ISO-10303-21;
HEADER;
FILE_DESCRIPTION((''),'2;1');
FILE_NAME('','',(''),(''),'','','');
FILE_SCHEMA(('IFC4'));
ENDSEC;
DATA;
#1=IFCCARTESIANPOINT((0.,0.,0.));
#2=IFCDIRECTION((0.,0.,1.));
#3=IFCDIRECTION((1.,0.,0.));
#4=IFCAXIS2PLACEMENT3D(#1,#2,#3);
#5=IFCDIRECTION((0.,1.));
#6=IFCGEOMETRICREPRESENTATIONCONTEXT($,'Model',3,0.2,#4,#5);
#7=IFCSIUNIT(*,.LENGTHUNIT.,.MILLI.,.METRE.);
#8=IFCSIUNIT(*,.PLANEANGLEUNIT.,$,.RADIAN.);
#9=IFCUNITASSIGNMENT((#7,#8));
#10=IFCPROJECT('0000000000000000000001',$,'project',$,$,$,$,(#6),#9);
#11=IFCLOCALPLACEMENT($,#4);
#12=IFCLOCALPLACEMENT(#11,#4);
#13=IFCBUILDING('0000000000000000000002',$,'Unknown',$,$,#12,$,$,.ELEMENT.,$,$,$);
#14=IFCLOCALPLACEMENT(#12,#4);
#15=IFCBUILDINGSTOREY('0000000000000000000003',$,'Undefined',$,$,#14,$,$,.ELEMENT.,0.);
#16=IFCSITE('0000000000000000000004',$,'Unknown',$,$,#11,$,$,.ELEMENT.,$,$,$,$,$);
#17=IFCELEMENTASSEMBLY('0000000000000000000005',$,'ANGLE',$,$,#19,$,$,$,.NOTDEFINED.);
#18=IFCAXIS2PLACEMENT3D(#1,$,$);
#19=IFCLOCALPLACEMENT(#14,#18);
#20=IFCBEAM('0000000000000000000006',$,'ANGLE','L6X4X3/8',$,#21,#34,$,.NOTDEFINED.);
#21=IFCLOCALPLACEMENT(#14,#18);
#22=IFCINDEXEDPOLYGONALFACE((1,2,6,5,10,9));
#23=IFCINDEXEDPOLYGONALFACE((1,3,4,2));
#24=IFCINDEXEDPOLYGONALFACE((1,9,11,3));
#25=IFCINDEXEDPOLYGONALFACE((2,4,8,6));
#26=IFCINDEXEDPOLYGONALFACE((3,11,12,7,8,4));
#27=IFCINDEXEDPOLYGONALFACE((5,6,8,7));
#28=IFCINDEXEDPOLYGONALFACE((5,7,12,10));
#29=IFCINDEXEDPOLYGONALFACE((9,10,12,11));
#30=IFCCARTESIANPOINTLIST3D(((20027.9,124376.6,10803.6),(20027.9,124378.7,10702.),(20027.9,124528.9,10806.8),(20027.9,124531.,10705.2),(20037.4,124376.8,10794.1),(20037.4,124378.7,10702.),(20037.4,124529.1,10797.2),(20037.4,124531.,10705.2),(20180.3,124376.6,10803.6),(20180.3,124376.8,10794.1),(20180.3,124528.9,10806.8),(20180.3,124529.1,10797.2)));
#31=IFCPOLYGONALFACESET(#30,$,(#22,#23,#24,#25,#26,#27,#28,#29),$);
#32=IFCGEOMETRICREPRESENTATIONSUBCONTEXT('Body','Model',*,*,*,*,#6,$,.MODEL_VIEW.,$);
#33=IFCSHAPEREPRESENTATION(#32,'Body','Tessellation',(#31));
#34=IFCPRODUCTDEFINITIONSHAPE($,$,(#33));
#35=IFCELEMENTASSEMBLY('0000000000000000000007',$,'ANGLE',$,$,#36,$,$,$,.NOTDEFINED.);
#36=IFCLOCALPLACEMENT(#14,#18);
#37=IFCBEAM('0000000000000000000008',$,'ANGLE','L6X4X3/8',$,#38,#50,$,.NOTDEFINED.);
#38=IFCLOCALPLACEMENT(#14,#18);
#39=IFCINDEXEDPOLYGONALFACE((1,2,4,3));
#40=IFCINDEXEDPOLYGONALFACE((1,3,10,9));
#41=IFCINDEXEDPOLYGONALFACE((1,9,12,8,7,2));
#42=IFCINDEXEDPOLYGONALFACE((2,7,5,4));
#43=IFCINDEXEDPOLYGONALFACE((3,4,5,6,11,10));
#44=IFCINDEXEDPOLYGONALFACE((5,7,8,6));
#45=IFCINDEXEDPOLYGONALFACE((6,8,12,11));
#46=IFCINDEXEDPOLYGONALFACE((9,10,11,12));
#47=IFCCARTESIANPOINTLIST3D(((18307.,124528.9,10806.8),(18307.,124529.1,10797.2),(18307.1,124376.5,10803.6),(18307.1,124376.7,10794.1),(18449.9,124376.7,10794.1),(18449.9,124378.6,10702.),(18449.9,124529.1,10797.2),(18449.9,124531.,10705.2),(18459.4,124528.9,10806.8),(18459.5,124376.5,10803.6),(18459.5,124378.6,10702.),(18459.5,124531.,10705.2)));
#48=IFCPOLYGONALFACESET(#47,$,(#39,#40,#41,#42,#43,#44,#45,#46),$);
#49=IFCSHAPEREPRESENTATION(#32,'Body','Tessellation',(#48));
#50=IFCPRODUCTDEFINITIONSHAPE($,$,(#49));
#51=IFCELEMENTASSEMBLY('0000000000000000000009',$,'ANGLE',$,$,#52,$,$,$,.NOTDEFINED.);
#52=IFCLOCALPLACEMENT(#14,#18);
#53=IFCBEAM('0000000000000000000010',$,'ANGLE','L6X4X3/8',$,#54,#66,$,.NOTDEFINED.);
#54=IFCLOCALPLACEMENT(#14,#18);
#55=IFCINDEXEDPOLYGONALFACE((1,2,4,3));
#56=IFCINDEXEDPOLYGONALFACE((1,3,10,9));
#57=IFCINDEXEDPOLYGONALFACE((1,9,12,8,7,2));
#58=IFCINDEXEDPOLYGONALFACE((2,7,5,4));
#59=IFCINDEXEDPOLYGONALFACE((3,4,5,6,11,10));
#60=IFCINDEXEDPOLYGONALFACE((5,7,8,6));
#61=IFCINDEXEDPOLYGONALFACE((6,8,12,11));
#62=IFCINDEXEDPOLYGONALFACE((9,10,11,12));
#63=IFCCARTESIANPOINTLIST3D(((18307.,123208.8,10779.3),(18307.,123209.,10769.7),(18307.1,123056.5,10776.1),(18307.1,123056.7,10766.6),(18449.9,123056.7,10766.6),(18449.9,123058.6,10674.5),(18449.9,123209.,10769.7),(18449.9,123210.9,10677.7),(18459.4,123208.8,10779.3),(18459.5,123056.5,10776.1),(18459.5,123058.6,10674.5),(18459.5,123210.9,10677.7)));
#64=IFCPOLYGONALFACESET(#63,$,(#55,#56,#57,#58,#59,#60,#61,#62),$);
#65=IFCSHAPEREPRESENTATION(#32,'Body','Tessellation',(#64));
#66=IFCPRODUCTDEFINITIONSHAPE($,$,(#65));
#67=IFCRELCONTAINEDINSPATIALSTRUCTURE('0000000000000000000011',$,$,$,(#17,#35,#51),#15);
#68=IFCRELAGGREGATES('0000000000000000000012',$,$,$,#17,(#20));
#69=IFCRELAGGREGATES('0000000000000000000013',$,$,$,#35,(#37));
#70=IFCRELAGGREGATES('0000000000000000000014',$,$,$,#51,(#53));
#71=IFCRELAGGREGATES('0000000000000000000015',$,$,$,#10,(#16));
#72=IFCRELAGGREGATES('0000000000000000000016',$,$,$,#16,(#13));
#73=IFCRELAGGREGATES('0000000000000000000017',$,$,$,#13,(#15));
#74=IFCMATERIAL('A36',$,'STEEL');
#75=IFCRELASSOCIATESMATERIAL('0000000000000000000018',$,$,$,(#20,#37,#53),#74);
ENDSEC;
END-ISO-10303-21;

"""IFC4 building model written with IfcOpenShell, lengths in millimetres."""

from ifc_helpers import new_model, si_unit, direction, frame, origin_with_axes, place, context, subcontext, project, spatial, line, indexed_curve, outline, extrude, material, element, aggregate, save


model = new_model("IFC4")

# Units and contexts
model_context = context("Model", 3, precision=0.2, world=origin_with_axes(), true_north=direction((0.0, 1.0)))
body_context = subcontext(model_context, "Body", "Model", "MODEL_VIEW")
ifc_project = project(units=[si_unit("LENGTHUNIT", "METRE", prefix="MILLI"), si_unit("PLANEANGLEUNIT", "RADIAN")], contexts=[model_context])

# Site, building, storey
site_placement = place(None, origin_with_axes())
site = spatial("IfcSite", under=ifc_project, at=site_placement, Name="Unknown", CompositionType="ELEMENT")
building_placement = place(site_placement, origin_with_axes())
building = spatial("IfcBuilding", under=site, at=building_placement, Name="Unknown", CompositionType="ELEMENT")
storey_placement = place(building_placement, origin_with_axes())
storey = spatial("IfcBuildingStorey", under=building, at=storey_placement, Name="Undefined", CompositionType="ELEMENT", Elevation=0.0)

# Shared definitions
ifc_material_1 = material(Name="A36", Category="STEEL")

# Element assemblies, beams
assembly_1_placement = place(storey_placement, frame((20104.1, 124377.6, 10752.8), z_axis=(0.0, 0.020829, -0.999783), x_axis=(0.0, 0.999783, 0.020819)))
assembly_1 = element("IfcElementAssembly", 1, at=assembly_1_placement, inside=storey, Name="ANGLE", PredefinedType="NOTDEFINED")
beam_1_placement = place(assembly_1_placement, origin_with_axes())
beam_1 = element("IfcBeam", 2, at=beam_1_placement, material=ifc_material_1, Name="ANGLE", Description="L6X4X3/8", PredefinedType="NOTDEFINED", context=body_context, shape_type="SolidModel", body=[
    extrude(outline(indexed_curve([(-50.8, -76.2), (50.8, -76.2), (50.8, -66.7), (-41.3, -66.7), (-41.3, 76.2), (-50.8, 76.2)], segments=[line(1, 2, 3, 4, 5, 6, 1)])), frame((0.0, 0.0, 0.0), z_axis=(-1.0, 0.0, 0.0), x_axis=(0.0, 0.0, 1.0)), (0.0, 0.0, -1.0), 152.4),
])
aggregate(assembly_1, [beam_1])
assembly_2_placement = place(storey_placement, frame((18383.2, 124530.0, 10756.0), z_axis=(0.0, 0.020829, -0.999783), x_axis=(0.0, -0.999783, -0.020831)))
assembly_2 = element("IfcElementAssembly", 3, at=assembly_2_placement, inside=storey, Name="ANGLE", PredefinedType="NOTDEFINED")
beam_2_placement = place(assembly_2_placement, origin_with_axes())
beam_2 = element("IfcBeam", 4, at=beam_2_placement, material=ifc_material_1, Name="ANGLE", Description="L6X4X3/8", PredefinedType="NOTDEFINED", context=body_context, shape_type="SolidModel", body=[
    extrude(outline(indexed_curve([(-50.8, -76.2), (50.8, -76.2), (50.8, -66.7), (-41.3, -66.7), (-41.3, 76.2), (-50.8, 76.2)], segments=[line(1, 2, 3, 4, 5, 6, 1)])), frame((0.0, 0.0, 0.0), z_axis=(-1.0, 0.0, 0.0), x_axis=(0.0, 0.0, 1.0)), (0.0, 0.0, -1.0), 152.4),
])
aggregate(assembly_2, [beam_2])
assembly_3_placement = place(storey_placement, frame((18383.2, 123209.9, 10728.5), z_axis=(0.0, 0.020829, -0.999783), x_axis=(0.0, -0.999783, -0.020831)))
assembly_3 = element("IfcElementAssembly", 5, at=assembly_3_placement, inside=storey, Name="ANGLE", PredefinedType="NOTDEFINED")
beam_3_placement = place(assembly_3_placement, origin_with_axes())
beam_3 = element("IfcBeam", 6, at=beam_3_placement, material=ifc_material_1, Name="ANGLE", Description="L6X4X3/8", PredefinedType="NOTDEFINED", context=body_context, shape_type="SolidModel", body=[
    extrude(outline(indexed_curve([(-50.8, -76.2), (50.8, -76.2), (50.8, -66.7), (-41.3, -66.7), (-41.3, 76.2), (-50.8, 76.2)], segments=[line(1, 2, 3, 4, 5, 6, 1)])), frame((0.0, 0.0, 0.0), z_axis=(-1.0, 0.0, 0.0), x_axis=(0.0, 0.0, 1.0)), (0.0, 0.0, -1.0), 152.4),
])
aggregate(assembly_3, [beam_3])

save(model, "model.ifc")
